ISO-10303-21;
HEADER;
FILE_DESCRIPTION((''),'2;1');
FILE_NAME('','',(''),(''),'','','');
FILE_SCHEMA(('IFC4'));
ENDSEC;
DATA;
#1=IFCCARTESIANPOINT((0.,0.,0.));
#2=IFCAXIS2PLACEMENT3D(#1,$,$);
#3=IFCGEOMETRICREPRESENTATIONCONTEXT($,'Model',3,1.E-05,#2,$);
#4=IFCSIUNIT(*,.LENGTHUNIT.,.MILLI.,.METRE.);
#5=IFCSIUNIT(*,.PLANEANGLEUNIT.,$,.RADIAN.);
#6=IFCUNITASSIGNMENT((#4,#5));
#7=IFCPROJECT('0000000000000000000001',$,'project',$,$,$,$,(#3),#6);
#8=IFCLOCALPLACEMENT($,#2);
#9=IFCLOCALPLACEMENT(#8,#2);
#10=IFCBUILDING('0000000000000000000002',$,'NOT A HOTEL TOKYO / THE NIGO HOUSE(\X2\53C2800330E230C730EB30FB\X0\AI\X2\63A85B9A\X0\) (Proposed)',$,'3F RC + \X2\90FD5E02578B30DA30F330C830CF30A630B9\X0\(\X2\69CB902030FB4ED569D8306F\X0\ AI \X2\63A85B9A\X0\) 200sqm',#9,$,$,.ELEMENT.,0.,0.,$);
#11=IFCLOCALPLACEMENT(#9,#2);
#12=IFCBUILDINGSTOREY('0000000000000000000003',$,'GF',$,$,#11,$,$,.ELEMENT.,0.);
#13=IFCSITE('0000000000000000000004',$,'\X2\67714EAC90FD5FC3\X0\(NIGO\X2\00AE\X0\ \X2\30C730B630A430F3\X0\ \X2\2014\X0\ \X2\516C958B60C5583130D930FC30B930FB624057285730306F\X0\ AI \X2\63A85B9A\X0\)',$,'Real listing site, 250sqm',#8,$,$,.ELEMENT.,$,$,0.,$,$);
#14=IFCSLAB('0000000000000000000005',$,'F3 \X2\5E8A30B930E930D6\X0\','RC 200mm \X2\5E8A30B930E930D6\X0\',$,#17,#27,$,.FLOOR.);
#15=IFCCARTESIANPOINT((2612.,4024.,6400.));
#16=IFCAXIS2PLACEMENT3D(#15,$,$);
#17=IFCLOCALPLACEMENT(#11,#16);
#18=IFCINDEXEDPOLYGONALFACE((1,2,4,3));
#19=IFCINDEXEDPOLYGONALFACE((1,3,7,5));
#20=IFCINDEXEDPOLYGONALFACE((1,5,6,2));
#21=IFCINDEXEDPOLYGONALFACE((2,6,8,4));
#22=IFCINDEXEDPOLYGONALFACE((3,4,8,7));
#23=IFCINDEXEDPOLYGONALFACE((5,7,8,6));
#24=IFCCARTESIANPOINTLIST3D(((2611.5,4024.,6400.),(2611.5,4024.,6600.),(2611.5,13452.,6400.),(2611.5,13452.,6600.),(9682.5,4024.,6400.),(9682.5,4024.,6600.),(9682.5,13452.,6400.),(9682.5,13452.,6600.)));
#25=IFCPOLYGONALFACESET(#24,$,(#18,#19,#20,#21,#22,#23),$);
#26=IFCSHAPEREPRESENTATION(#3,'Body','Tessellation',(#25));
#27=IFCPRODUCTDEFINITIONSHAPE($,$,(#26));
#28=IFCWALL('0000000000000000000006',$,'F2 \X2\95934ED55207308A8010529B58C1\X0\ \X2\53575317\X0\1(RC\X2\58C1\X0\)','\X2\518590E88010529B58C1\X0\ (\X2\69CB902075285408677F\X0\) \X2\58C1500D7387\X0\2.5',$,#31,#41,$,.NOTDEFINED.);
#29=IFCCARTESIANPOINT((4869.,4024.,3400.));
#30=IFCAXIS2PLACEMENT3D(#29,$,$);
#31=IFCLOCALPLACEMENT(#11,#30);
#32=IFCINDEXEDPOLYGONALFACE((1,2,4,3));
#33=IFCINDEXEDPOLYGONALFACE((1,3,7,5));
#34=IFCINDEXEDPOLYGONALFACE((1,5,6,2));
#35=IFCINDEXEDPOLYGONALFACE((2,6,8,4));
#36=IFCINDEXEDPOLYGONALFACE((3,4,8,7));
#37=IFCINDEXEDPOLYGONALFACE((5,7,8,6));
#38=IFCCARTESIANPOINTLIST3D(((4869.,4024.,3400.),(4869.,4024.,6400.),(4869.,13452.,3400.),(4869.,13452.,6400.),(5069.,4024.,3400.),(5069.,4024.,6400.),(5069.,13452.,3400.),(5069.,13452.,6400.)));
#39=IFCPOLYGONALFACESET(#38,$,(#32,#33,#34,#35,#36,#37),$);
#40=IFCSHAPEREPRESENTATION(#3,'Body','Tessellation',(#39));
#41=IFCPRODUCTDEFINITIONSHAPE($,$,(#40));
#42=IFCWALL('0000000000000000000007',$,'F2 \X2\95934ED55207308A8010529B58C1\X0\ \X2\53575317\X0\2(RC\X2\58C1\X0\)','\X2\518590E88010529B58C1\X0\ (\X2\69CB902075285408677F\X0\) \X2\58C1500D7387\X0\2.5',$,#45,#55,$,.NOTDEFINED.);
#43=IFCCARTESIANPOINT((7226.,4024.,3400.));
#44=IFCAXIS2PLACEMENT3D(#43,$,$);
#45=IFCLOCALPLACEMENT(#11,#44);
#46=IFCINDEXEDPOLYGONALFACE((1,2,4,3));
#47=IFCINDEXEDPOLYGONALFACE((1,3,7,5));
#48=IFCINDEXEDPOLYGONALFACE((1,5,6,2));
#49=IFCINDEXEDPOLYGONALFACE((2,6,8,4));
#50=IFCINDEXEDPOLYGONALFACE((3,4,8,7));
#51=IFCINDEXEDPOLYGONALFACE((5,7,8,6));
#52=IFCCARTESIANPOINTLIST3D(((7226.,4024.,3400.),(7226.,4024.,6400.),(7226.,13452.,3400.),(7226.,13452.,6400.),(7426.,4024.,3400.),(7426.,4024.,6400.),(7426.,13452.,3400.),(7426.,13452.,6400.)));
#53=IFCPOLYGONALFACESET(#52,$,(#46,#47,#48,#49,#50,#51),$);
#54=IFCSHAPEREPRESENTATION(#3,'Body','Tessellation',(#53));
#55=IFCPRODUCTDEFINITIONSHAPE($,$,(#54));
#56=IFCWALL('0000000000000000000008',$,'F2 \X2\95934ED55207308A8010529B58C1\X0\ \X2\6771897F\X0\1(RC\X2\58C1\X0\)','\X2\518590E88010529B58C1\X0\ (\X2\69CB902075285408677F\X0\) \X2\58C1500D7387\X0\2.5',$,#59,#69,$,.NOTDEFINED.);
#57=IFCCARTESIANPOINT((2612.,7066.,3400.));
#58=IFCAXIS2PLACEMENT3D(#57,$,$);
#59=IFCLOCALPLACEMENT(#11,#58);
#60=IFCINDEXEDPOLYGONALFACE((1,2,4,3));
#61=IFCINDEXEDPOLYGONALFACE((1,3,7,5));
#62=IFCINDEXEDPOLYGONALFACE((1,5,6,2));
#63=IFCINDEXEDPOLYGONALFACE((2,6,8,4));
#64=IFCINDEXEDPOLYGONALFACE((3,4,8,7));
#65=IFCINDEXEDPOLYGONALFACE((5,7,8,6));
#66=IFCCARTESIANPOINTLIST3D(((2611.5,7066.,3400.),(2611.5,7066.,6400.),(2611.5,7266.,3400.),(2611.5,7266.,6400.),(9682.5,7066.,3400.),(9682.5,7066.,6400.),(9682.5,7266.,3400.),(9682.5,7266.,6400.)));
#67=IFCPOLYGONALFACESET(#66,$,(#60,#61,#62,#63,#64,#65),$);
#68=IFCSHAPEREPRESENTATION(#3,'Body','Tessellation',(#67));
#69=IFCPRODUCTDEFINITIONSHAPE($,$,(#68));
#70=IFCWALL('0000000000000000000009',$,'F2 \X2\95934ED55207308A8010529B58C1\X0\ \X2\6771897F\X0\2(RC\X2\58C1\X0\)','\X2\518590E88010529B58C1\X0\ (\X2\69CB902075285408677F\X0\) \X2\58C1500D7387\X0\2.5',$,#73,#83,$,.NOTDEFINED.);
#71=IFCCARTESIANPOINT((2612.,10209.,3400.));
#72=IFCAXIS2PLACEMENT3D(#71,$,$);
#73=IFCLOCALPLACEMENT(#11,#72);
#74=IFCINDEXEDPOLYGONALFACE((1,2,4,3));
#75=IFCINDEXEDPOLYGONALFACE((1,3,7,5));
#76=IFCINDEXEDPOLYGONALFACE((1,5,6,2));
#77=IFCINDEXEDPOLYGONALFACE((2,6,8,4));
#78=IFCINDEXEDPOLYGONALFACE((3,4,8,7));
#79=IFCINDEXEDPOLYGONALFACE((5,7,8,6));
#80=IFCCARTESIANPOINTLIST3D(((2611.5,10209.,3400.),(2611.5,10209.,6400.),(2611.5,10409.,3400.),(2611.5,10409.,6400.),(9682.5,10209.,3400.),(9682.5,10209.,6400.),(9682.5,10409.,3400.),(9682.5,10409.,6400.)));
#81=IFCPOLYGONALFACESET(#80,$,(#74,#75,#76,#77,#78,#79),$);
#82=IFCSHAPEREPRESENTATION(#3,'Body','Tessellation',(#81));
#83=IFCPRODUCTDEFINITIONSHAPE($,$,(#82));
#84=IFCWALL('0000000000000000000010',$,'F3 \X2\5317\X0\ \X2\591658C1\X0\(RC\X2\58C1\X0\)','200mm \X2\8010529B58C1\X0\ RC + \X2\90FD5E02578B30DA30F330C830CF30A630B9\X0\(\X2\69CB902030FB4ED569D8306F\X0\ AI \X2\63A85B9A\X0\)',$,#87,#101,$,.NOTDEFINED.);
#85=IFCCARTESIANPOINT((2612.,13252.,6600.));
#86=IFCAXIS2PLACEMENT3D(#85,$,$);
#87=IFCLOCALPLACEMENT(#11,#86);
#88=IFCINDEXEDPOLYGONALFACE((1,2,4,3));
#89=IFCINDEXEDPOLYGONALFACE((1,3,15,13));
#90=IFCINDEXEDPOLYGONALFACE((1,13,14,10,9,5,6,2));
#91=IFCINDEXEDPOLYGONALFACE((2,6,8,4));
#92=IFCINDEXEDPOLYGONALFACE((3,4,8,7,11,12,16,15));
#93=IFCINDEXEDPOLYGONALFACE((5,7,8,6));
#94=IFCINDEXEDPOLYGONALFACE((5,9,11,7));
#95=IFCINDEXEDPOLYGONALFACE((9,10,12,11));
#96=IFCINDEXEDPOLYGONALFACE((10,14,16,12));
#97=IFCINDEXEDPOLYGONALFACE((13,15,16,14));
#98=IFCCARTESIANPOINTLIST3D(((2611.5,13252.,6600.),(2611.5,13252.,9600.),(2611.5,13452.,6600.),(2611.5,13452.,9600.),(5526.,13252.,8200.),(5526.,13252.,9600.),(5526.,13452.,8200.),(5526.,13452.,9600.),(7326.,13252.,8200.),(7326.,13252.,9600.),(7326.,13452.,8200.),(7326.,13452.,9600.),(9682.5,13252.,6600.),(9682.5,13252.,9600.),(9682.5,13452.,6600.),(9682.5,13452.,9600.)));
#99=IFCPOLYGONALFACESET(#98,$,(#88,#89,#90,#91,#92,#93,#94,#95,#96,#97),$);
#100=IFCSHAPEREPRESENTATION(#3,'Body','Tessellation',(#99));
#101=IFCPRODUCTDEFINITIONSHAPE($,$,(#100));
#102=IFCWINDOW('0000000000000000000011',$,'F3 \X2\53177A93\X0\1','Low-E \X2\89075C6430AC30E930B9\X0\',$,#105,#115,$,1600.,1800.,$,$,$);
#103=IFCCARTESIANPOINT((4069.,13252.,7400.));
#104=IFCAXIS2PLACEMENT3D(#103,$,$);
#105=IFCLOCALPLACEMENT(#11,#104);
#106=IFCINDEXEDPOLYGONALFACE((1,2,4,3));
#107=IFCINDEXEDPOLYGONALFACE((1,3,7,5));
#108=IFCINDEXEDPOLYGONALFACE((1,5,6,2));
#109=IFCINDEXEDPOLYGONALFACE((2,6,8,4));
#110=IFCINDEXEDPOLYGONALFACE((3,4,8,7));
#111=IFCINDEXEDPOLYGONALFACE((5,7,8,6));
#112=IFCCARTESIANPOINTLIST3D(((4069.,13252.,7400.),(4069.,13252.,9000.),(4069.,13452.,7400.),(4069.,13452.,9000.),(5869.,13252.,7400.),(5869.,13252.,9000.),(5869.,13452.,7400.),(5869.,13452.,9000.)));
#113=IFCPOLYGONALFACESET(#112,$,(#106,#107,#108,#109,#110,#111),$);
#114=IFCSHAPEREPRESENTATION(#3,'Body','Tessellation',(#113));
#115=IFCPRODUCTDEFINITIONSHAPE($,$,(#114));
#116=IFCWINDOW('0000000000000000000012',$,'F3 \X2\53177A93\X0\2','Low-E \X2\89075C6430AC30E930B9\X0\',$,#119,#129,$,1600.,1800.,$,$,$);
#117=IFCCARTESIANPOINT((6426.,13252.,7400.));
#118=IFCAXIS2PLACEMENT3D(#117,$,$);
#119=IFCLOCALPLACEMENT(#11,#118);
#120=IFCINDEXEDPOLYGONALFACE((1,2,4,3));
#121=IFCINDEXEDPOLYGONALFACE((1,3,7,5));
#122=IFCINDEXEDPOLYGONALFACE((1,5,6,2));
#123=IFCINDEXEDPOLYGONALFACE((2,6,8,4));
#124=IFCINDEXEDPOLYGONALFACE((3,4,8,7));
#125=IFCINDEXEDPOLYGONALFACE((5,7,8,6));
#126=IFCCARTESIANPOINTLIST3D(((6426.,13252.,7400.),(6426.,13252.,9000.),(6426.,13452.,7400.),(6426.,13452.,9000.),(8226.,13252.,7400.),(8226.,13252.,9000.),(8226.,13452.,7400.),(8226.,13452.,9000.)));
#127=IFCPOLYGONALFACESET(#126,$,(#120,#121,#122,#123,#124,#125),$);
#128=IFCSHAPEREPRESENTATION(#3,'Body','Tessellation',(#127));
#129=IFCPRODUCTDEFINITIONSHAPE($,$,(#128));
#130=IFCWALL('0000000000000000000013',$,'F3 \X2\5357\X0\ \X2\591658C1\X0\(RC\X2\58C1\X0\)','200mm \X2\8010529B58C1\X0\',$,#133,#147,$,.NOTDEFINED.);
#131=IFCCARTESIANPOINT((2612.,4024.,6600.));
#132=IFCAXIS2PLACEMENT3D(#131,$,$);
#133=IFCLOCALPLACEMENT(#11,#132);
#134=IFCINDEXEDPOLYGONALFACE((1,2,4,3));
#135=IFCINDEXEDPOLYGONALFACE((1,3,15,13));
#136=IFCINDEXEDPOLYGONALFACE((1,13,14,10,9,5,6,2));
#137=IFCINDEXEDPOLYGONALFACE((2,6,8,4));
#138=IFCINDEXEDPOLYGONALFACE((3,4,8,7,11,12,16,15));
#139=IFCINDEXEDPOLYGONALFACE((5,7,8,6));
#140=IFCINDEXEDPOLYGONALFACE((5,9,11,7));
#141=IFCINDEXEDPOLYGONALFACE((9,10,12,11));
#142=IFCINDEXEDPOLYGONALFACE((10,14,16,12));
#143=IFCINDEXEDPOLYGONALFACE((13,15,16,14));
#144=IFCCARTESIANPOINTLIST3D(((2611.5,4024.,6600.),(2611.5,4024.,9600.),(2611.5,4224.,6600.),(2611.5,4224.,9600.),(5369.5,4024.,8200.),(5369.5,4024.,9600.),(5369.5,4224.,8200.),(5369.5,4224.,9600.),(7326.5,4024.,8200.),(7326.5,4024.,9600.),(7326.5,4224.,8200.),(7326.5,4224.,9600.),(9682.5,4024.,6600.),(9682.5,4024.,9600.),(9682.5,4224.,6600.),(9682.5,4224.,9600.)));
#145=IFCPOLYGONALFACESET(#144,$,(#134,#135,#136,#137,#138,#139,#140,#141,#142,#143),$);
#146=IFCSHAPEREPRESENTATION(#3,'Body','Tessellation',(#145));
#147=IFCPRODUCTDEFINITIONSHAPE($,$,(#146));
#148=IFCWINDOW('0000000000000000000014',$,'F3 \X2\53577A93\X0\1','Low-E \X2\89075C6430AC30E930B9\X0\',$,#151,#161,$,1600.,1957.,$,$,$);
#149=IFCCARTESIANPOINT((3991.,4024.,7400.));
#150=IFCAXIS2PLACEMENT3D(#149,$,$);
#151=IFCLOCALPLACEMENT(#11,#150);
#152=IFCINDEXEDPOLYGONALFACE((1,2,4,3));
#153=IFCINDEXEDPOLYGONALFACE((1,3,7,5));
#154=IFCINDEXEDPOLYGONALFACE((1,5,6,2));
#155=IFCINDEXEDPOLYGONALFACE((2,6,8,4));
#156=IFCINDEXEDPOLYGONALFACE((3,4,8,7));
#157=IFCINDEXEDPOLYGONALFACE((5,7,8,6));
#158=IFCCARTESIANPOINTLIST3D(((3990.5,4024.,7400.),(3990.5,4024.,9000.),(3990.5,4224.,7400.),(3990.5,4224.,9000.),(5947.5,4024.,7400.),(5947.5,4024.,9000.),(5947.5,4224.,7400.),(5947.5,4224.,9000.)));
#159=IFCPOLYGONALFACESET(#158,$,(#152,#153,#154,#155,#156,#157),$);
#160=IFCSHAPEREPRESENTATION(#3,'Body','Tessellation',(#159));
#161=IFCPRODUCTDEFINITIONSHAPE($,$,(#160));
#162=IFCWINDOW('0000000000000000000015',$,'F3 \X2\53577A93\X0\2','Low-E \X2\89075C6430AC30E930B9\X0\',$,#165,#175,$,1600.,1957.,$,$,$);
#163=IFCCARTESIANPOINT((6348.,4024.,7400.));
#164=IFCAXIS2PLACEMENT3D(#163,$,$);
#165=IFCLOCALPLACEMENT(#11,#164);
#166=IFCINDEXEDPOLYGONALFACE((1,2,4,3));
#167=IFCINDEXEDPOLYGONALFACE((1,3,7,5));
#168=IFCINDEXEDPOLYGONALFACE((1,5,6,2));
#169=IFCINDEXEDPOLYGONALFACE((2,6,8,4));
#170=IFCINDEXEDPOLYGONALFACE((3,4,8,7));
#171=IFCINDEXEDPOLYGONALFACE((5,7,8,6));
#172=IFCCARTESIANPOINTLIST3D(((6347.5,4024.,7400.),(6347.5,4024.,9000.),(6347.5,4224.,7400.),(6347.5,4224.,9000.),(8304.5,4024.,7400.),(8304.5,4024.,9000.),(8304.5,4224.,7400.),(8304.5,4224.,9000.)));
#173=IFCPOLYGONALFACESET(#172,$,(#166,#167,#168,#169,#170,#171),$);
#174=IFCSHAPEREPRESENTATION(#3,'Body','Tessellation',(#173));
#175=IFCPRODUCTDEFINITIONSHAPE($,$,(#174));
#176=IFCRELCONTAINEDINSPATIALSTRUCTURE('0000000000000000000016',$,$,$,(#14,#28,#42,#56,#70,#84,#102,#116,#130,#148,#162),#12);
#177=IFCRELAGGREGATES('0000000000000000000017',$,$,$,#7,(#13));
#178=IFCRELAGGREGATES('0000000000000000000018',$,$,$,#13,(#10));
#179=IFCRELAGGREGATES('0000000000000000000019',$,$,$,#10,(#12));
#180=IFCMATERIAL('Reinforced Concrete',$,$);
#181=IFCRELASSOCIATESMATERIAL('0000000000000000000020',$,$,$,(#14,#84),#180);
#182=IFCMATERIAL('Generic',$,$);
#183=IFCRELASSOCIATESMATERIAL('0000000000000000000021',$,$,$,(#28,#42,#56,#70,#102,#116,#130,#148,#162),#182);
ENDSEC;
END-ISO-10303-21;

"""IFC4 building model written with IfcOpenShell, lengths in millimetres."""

from ifc_helpers import new_model, si_unit, frame, frame_2d, origin, place, context, project, spatial, rectangle, extrude, material, element, fill, save


model = new_model("IFC4")

# Units and contexts
model_context = context("Model", 3, precision=1e-05, world=origin())
ifc_project = project(units=[si_unit("LENGTHUNIT", "METRE", prefix="MILLI"), si_unit("PLANEANGLEUNIT", "RADIAN")], contexts=[model_context])

# Site, building, storey
site_placement = place(None, origin())
site = spatial("IfcSite", under=ifc_project, at=site_placement, Name="東京都心(NIGO® デザイン — 公開情報ベース・所在地は AI 推定)", ObjectType="Real listing site, 250sqm", CompositionType="ELEMENT", RefElevation=0.0)
building_placement = place(site_placement, origin())
building = spatial("IfcBuilding", under=site, at=building_placement, Name="NOT A HOTEL TOKYO / THE NIGO HOUSE(参考モデル・AI推定) (Proposed)", ObjectType="3F RC + 都市型ペントハウス(構造・仕様は AI 推定) 200sqm", CompositionType="ELEMENT", ElevationOfRefHeight=0.0, ElevationOfTerrain=0.0)
storey_placement = place(building_placement, origin())
storey = spatial("IfcBuildingStorey", under=building, at=storey_placement, Name="GF", CompositionType="ELEMENT", Elevation=0.0)

# Slab
ifc_material_1 = material(Name="Reinforced Concrete")
slab_placement = place(storey_placement, frame((2612.0, 4024.0, 6400.0)))
element("IfcSlab", 1, at=slab_placement, inside=storey, material=ifc_material_1, Name="F3 床スラブ", Description="RC 200mm 床スラブ", PredefinedType="FLOOR", context=model_context, shape_type="SweptSolid", body=[
    extrude(rectangle(XDim=7071.0, YDim=9428.0, at=frame_2d((3535.0, 4714.0))), frame((2612.0, 4024.0, 6400.0)), (0.0, 0.0, 1.0), 200.0),
])

# Walls
ifc_material_2 = material(Name="Generic")
wall_1_placement = place(storey_placement, frame((4869.0, 4024.0, 3400.0)))
element("IfcWall", 2, at=wall_1_placement, inside=storey, material=ifc_material_2, Name="F2 間仕切り耐力壁 南北1(RC壁)", Description="内部耐力壁 (構造用合板) 壁倍率2.5", PredefinedType="NOTDEFINED", context=model_context, shape_type="SweptSolid", body=[
    extrude(rectangle(XDim=200.0, YDim=9428.0, at=frame_2d((100.0, 4714.0))), frame((4869.0, 4024.0, 3400.0)), (0.0, 0.0, 1.0), 3000.0),
])
wall_2_placement = place(storey_placement, frame((7226.0, 4024.0, 3400.0)))
element("IfcWall", 3, at=wall_2_placement, inside=storey, material=ifc_material_2, Name="F2 間仕切り耐力壁 南北2(RC壁)", Description="内部耐力壁 (構造用合板) 壁倍率2.5", PredefinedType="NOTDEFINED", context=model_context, shape_type="SweptSolid", body=[
    extrude(rectangle(XDim=200.0, YDim=9428.0, at=frame_2d((100.0, 4714.0))), frame((7226.0, 4024.0, 3400.0)), (0.0, 0.0, 1.0), 3000.0),
])
wall_3_placement = place(storey_placement, frame((2612.0, 7066.0, 3400.0)))
element("IfcWall", 4, at=wall_3_placement, inside=storey, material=ifc_material_2, Name="F2 間仕切り耐力壁 東西1(RC壁)", Description="内部耐力壁 (構造用合板) 壁倍率2.5", PredefinedType="NOTDEFINED", context=model_context, shape_type="SweptSolid", body=[
    extrude(rectangle(XDim=7071.0, YDim=200.0, at=frame_2d((3535.0, 100.0))), frame((2612.0, 7066.0, 3400.0)), (0.0, 0.0, 1.0), 3000.0),
])
wall_4_placement = place(storey_placement, frame((2612.0, 10209.0, 3400.0)))
element("IfcWall", 5, at=wall_4_placement, inside=storey, material=ifc_material_2, Name="F2 間仕切り耐力壁 東西2(RC壁)", Description="内部耐力壁 (構造用合板) 壁倍率2.5", PredefinedType="NOTDEFINED", context=model_context, shape_type="SweptSolid", body=[
    extrude(rectangle(XDim=7071.0, YDim=200.0, at=frame_2d((3535.0, 100.0))), frame((2612.0, 10209.0, 3400.0)), (0.0, 0.0, 1.0), 3000.0),
])

# Walls, openings, windows
wall_5_placement = place(storey_placement, frame((2612.0, 13252.0, 6600.0)))
wall_5 = element("IfcWall", 6, at=wall_5_placement, inside=storey, material=ifc_material_1, Name="F3 北 外壁(RC壁)", Description="200mm 耐力壁 RC + 都市型ペントハウス(構造・仕様は AI 推定)", PredefinedType="NOTDEFINED", context=model_context, shape_type="SweptSolid", body=[
    extrude(rectangle(XDim=7071.0, YDim=200.0, at=frame_2d((3535.0, 100.0))), frame((2612.0, 13252.0, 6600.0)), (0.0, 0.0, 1.0), 3000.0),
])
opening_1_placement = place(storey_placement, frame((4069.0, 13252.0, 7400.0)))
opening_1 = element("IfcOpeningElement", 7, at=opening_1_placement, cuts=wall_5, PredefinedType="NOTDEFINED", context=model_context, shape_type="SweptSolid", body=[
    extrude(rectangle(XDim=1800.0, YDim=200.0, at=frame_2d((900.0, 100.0))), frame((4069.0, 13252.0, 7400.0)), (0.0, 0.0, 1.0), 1600.0),
])
opening_2_placement = place(storey_placement, frame((6426.0, 13252.0, 7400.0)))
opening_2 = element("IfcOpeningElement", 8, at=opening_2_placement, cuts=wall_5, PredefinedType="NOTDEFINED", context=model_context, shape_type="SweptSolid", body=[
    extrude(rectangle(XDim=1800.0, YDim=200.0, at=frame_2d((900.0, 100.0))), frame((6426.0, 13252.0, 7400.0)), (0.0, 0.0, 1.0), 1600.0),
])
window_1_placement = place(storey_placement, frame((4069.0, 13252.0, 7400.0)))
window_1 = element("IfcWindow", 9, at=window_1_placement, inside=storey, material=ifc_material_2, Name="F3 北窓1", Description="Low-E 複層ガラス", OverallHeight=1600.0, OverallWidth=1800.0, context=model_context, shape_type="SweptSolid", body=[
    extrude(rectangle(XDim=1800.0, YDim=200.0, at=frame_2d((900.0, 100.0))), frame((4069.0, 13252.0, 7400.0)), (0.0, 0.0, 1.0), 1600.0),
])
fill(opening_1, window_1)
window_2_placement = place(storey_placement, frame((6426.0, 13252.0, 7400.0)))
window_2 = element("IfcWindow", 10, at=window_2_placement, inside=storey, material=ifc_material_2, Name="F3 北窓2", Description="Low-E 複層ガラス", OverallHeight=1600.0, OverallWidth=1800.0, context=model_context, shape_type="SweptSolid", body=[
    extrude(rectangle(XDim=1800.0, YDim=200.0, at=frame_2d((900.0, 100.0))), frame((6426.0, 13252.0, 7400.0)), (0.0, 0.0, 1.0), 1600.0),
])
fill(opening_2, window_2)
wall_6_placement = place(storey_placement, frame((2612.0, 4024.0, 6600.0)))
wall_6 = element("IfcWall", 11, at=wall_6_placement, inside=storey, material=ifc_material_2, Name="F3 南 外壁(RC壁)", Description="200mm 耐力壁", PredefinedType="NOTDEFINED", context=model_context, shape_type="SweptSolid", body=[
    extrude(rectangle(XDim=7071.0, YDim=200.0, at=frame_2d((3535.0, 100.0))), frame((2612.0, 4024.0, 6600.0)), (0.0, 0.0, 1.0), 3000.0),
])
opening_3_placement = place(storey_placement, frame((3991.0, 4024.0, 7400.0)))
opening_3 = element("IfcOpeningElement", 12, at=opening_3_placement, cuts=wall_6, PredefinedType="NOTDEFINED", context=model_context, shape_type="SweptSolid", body=[
    extrude(rectangle(XDim=1957.0, YDim=200.0, at=frame_2d((978.0, 100.0))), frame((3991.0, 4024.0, 7400.0)), (0.0, 0.0, 1.0), 1600.0),
])
opening_4_placement = place(storey_placement, frame((6348.0, 4024.0, 7400.0)))
opening_4 = element("IfcOpeningElement", 13, at=opening_4_placement, cuts=wall_6, PredefinedType="NOTDEFINED", context=model_context, shape_type="SweptSolid", body=[
    extrude(rectangle(XDim=1957.0, YDim=200.0, at=frame_2d((978.0, 100.0))), frame((6348.0, 4024.0, 7400.0)), (0.0, 0.0, 1.0), 1600.0),
])
window_3_placement = place(storey_placement, frame((3991.0, 4024.0, 7400.0)))
window_3 = element("IfcWindow", 14, at=window_3_placement, inside=storey, material=ifc_material_2, Name="F3 南窓1", Description="Low-E 複層ガラス", OverallHeight=1600.0, OverallWidth=1957.0, context=model_context, shape_type="SweptSolid", body=[
    extrude(rectangle(XDim=1957.0, YDim=200.0, at=frame_2d((978.0, 100.0))), frame((3991.0, 4024.0, 7400.0)), (0.0, 0.0, 1.0), 1600.0),
])
fill(opening_3, window_3)
window_4_placement = place(storey_placement, frame((6348.0, 4024.0, 7400.0)))
window_4 = element("IfcWindow", 15, at=window_4_placement, inside=storey, material=ifc_material_2, Name="F3 南窓2", Description="Low-E 複層ガラス", OverallHeight=1600.0, OverallWidth=1957.0, context=model_context, shape_type="SweptSolid", body=[
    extrude(rectangle(XDim=1957.0, YDim=200.0, at=frame_2d((978.0, 100.0))), frame((6348.0, 4024.0, 7400.0)), (0.0, 0.0, 1.0), 1600.0),
])
fill(opening_4, window_4)

save(model, "model.ifc")
